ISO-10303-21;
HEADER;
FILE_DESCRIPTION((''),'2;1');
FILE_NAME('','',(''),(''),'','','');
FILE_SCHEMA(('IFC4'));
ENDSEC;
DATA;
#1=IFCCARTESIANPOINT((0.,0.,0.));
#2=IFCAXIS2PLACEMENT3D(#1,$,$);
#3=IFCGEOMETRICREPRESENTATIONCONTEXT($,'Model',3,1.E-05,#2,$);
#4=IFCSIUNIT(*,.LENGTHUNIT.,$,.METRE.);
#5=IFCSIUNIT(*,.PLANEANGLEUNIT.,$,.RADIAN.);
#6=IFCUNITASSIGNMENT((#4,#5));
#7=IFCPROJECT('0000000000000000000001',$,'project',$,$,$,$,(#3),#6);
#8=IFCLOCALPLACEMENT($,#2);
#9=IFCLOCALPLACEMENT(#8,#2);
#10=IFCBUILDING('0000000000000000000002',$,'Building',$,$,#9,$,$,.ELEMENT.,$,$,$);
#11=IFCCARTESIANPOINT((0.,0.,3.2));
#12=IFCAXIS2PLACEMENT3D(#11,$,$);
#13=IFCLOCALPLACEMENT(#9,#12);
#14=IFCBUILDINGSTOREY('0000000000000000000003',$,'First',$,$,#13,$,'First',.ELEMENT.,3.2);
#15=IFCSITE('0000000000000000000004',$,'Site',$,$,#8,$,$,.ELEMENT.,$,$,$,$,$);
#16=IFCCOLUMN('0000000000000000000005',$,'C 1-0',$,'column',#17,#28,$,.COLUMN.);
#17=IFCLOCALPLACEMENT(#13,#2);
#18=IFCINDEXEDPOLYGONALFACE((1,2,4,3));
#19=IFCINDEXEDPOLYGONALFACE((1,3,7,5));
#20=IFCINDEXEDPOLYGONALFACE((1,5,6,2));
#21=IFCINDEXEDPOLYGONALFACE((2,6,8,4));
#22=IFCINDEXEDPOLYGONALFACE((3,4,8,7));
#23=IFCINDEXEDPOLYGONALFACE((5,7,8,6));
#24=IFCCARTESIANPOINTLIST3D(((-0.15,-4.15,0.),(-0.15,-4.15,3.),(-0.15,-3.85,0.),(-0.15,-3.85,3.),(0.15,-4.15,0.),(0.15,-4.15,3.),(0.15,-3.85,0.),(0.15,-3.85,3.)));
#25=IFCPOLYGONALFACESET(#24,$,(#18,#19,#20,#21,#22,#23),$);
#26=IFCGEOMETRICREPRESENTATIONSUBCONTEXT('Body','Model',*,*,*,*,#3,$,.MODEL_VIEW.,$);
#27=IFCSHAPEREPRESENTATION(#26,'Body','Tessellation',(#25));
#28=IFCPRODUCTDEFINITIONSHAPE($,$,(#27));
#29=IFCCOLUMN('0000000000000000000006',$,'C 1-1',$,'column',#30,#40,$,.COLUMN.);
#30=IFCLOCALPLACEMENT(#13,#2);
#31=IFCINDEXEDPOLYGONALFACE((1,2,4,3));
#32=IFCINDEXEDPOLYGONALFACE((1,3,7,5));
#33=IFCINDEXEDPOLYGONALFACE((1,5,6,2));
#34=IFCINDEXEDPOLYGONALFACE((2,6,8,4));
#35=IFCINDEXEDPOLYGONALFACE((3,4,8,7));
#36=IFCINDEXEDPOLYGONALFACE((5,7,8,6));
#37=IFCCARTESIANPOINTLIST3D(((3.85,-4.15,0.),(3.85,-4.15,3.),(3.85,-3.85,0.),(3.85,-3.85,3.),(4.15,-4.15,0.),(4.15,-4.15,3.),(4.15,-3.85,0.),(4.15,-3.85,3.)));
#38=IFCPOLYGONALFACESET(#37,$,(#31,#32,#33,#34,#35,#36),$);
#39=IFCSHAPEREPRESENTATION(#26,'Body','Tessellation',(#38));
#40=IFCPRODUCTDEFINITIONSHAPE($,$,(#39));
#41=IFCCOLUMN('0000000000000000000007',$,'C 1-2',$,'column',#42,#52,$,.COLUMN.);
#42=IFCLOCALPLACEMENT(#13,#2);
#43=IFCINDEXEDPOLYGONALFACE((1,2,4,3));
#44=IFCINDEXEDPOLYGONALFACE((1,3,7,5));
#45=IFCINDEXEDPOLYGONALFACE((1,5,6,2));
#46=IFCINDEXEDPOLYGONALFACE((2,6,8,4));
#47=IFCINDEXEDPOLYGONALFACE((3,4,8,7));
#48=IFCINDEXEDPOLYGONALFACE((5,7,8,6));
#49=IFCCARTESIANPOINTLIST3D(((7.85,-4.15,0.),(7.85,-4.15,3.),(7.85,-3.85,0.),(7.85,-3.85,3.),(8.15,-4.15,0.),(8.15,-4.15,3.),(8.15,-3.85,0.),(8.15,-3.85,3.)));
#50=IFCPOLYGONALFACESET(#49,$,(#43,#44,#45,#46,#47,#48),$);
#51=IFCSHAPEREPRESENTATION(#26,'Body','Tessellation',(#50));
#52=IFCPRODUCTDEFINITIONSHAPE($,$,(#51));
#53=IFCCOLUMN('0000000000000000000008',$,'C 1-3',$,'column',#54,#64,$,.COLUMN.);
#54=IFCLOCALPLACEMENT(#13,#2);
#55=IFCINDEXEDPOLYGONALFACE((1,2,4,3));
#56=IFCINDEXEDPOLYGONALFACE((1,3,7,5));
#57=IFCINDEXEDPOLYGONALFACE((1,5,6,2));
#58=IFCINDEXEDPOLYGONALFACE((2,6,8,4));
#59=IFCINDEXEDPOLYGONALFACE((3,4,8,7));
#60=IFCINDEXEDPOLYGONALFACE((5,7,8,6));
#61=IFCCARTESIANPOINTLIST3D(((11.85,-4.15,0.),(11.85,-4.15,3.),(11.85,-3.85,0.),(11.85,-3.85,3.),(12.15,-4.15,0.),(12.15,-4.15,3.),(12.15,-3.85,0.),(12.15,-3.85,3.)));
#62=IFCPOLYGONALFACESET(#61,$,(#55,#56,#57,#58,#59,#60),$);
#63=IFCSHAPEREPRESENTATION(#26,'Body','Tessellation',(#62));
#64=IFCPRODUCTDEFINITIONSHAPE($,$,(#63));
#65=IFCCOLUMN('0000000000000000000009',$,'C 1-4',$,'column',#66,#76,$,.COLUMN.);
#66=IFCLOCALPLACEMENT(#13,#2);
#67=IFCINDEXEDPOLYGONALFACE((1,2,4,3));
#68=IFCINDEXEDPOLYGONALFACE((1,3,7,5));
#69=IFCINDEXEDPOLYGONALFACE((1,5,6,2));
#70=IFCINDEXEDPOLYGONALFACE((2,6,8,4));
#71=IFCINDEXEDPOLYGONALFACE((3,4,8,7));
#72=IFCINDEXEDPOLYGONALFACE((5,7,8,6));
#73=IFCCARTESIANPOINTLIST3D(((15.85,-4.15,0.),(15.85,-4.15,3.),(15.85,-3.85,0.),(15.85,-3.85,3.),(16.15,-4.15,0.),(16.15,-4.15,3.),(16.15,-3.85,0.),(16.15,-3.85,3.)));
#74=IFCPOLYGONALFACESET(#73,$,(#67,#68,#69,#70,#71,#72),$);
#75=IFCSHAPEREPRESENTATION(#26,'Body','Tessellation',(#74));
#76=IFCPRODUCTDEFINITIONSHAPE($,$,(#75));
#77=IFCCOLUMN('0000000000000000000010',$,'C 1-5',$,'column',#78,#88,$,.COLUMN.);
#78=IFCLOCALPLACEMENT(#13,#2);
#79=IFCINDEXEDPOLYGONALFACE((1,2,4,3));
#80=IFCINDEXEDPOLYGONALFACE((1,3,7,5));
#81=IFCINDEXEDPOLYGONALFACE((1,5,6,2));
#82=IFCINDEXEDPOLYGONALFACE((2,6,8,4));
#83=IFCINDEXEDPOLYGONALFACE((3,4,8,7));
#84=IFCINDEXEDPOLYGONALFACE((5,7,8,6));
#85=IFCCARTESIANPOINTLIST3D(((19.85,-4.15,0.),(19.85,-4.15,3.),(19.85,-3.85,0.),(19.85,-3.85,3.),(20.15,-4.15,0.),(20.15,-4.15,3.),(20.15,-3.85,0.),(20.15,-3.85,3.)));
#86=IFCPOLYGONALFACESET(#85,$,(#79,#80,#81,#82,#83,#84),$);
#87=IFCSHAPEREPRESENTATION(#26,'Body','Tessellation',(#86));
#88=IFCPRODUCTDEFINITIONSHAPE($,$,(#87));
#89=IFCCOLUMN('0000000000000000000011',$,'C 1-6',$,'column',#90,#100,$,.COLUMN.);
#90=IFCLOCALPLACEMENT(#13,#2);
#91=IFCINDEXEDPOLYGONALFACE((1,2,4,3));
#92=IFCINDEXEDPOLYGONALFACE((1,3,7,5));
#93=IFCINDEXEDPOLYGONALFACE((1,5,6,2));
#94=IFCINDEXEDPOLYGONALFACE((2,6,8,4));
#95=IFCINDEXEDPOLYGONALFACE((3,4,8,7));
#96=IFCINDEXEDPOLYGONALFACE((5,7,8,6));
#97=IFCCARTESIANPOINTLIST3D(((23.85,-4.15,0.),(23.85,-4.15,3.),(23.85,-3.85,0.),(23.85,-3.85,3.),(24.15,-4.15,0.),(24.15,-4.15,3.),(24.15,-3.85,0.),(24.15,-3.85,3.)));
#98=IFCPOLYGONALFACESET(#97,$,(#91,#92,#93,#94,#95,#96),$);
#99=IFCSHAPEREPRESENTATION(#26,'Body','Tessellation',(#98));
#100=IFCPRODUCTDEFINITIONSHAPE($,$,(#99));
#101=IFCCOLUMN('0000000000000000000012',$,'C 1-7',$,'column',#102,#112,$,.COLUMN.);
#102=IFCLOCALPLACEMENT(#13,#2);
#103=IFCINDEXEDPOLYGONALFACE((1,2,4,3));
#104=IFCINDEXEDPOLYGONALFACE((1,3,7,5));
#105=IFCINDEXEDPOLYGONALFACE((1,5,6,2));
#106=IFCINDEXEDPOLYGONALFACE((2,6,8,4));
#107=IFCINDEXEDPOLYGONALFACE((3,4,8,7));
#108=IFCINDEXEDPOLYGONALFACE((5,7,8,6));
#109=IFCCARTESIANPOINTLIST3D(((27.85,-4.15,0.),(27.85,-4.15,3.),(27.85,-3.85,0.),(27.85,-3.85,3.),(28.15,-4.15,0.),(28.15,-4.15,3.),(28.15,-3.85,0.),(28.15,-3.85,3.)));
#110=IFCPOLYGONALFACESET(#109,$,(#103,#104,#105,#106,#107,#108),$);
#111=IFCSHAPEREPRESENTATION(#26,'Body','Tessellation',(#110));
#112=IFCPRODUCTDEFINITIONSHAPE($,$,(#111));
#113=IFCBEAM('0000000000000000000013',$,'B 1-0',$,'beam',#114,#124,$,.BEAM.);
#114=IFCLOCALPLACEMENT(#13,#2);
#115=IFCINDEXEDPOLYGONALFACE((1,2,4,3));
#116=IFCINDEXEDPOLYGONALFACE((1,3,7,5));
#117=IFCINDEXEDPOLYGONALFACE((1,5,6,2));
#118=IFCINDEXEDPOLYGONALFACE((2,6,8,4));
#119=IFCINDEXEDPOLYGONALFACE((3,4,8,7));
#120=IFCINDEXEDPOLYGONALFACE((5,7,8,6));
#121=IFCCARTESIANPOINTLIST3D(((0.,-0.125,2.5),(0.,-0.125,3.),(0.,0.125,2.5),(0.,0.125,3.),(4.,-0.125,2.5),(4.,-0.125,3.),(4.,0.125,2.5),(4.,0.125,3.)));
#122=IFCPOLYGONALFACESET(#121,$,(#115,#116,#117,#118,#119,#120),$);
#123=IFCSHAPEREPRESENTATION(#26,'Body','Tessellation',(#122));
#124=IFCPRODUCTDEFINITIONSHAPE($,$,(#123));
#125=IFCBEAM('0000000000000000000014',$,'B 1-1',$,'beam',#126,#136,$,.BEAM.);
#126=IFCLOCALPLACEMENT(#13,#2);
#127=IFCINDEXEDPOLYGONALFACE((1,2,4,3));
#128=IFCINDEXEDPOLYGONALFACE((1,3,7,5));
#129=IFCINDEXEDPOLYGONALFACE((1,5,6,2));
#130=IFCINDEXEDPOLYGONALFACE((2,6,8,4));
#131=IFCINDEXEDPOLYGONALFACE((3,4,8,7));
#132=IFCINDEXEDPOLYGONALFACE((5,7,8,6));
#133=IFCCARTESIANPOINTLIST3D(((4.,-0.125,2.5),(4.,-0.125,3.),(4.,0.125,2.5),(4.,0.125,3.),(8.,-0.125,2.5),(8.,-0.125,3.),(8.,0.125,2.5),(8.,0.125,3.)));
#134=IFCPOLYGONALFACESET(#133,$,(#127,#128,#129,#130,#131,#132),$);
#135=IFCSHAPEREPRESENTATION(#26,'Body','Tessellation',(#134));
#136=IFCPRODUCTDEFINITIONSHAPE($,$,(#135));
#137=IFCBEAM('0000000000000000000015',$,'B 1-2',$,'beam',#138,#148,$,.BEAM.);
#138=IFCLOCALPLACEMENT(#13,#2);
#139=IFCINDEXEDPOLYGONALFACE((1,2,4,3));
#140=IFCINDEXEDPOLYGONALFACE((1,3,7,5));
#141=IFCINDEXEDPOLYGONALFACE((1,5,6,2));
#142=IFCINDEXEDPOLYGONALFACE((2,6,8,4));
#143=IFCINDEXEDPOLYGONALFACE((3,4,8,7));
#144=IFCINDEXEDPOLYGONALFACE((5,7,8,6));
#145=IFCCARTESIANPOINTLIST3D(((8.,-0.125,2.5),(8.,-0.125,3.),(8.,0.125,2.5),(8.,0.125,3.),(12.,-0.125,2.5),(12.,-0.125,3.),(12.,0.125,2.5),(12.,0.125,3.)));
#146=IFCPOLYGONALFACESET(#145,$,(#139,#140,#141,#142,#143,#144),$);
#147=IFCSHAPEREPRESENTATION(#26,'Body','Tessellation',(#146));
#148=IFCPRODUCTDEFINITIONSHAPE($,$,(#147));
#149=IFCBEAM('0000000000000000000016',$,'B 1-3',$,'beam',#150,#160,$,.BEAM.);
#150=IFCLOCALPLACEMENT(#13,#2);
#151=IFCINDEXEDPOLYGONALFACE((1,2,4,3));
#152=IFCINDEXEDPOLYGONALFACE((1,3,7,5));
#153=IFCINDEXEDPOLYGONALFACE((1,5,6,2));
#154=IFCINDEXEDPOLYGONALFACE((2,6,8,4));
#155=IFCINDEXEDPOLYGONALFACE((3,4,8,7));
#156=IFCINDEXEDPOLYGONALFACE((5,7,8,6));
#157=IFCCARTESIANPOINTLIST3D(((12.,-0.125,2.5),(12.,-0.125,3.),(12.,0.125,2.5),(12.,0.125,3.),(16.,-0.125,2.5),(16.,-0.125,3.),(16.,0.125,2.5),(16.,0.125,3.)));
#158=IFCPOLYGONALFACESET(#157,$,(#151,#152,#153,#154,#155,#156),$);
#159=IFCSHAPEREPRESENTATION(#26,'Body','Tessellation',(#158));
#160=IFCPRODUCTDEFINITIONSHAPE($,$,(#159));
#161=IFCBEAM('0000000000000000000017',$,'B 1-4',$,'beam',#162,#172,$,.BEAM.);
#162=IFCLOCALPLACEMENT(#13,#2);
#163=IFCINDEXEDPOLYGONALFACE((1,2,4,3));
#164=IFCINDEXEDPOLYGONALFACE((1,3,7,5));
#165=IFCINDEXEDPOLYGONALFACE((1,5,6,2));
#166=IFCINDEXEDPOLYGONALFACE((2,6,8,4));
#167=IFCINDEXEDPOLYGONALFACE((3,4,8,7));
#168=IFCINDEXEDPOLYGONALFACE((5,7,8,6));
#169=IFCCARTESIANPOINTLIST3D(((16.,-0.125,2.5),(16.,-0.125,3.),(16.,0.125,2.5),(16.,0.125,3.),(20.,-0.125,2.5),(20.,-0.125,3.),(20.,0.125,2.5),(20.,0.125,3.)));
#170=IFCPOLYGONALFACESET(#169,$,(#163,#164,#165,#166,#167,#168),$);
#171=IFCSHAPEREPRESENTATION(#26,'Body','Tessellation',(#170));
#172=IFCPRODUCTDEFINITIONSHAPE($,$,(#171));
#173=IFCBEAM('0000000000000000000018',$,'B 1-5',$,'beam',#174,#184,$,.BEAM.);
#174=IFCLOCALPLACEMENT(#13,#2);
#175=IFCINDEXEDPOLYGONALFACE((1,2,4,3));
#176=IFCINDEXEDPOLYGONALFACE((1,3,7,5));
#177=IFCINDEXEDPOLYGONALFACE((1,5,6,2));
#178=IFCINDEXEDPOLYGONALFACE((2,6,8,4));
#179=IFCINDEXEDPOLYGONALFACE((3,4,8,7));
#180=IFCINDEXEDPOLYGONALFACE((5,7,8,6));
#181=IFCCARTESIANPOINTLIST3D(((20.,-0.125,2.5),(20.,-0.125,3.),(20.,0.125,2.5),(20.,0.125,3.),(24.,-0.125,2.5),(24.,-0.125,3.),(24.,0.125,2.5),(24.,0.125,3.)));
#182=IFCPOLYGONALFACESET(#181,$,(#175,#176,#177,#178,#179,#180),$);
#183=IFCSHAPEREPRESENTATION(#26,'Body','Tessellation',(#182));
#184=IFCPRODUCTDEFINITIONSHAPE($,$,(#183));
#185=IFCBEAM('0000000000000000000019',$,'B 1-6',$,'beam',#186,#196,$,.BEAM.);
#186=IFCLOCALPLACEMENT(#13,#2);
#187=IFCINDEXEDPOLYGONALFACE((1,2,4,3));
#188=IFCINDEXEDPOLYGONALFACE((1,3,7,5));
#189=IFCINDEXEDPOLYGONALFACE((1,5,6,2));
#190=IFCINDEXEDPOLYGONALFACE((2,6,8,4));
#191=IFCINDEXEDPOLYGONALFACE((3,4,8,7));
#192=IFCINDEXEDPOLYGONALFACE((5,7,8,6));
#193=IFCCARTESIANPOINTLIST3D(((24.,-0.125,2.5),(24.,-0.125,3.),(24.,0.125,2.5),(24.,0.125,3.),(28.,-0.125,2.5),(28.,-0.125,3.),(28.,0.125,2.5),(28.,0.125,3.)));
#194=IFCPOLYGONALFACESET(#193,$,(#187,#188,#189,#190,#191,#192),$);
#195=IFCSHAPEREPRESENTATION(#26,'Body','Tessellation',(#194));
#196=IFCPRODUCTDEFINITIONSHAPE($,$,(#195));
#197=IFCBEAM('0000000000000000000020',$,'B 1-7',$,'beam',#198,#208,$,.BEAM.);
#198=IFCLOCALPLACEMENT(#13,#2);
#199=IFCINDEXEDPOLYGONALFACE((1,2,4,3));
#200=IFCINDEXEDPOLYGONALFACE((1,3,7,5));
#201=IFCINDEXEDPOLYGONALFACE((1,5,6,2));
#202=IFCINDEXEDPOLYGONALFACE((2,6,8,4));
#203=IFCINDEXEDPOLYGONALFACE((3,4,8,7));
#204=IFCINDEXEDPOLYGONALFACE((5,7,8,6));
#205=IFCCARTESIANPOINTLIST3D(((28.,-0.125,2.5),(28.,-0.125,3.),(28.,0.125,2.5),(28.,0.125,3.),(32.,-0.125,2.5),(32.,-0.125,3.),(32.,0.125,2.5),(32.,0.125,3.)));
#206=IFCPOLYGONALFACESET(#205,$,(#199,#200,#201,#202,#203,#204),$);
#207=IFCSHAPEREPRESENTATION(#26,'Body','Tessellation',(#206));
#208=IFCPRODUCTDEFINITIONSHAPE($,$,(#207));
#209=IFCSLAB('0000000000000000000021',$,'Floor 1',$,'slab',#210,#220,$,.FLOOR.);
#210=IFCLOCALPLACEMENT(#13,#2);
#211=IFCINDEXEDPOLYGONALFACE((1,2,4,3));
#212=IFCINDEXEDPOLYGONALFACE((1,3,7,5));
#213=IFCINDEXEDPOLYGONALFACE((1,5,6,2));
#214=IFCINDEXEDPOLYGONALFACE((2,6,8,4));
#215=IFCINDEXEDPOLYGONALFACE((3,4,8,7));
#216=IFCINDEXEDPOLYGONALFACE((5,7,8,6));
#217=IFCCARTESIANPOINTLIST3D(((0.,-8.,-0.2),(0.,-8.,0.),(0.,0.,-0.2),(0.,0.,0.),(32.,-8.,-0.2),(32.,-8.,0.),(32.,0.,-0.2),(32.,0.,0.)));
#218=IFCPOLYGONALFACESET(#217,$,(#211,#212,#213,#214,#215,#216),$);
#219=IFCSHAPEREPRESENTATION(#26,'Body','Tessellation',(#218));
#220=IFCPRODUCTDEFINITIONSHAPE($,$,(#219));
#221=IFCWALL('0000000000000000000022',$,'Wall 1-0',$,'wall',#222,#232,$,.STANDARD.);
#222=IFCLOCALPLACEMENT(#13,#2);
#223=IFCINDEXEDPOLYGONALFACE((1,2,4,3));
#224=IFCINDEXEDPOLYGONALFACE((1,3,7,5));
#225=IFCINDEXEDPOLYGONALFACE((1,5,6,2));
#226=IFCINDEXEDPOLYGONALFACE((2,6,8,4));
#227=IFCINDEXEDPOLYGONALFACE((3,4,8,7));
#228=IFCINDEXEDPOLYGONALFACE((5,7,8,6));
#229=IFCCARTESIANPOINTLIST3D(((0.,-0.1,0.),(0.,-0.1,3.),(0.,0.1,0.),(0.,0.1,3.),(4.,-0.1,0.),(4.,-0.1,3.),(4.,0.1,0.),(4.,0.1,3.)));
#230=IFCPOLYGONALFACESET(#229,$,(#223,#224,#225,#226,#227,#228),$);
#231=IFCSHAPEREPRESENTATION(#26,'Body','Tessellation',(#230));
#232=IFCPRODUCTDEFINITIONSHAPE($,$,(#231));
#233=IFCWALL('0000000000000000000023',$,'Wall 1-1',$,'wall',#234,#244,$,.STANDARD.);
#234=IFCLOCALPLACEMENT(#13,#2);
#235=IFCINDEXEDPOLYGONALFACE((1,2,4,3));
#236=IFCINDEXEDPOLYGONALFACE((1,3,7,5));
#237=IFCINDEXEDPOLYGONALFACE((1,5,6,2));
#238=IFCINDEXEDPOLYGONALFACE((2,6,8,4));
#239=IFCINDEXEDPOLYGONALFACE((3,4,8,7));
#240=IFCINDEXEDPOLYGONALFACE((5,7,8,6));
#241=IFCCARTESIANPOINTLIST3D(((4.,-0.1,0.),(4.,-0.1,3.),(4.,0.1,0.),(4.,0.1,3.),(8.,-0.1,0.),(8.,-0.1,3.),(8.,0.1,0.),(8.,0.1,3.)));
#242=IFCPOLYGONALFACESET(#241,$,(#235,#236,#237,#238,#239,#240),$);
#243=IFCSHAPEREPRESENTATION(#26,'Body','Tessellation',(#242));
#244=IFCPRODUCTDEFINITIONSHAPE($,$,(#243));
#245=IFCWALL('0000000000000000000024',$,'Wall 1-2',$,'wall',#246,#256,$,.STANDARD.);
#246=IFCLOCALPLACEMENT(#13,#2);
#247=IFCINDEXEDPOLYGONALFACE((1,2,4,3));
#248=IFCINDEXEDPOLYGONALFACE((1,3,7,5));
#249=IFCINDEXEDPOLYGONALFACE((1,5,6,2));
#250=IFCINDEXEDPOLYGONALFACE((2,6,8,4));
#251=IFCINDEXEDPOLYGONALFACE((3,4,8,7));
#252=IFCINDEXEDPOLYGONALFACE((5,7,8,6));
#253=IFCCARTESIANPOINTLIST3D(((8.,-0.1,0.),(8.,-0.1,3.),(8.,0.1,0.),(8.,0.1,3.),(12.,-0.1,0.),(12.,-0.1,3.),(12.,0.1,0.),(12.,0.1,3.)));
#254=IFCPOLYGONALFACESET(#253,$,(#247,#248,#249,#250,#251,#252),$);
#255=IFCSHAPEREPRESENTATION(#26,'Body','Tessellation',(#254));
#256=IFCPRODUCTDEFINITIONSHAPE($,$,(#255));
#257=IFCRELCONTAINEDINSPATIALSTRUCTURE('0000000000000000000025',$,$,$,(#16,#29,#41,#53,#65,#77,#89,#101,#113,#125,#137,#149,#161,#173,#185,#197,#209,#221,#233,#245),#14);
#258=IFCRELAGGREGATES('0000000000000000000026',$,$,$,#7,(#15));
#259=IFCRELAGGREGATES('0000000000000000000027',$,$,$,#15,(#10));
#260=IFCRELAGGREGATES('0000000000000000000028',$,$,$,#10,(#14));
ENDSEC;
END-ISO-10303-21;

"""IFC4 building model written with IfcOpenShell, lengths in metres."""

from ifc_helpers import new_model, si_unit, frame, frame_2d, origin, origin_2d, place, context, subcontext, project, spatial, polyline, rectangle, outline, extrude, element, save


model = new_model("IFC4")

# Units and contexts
model_context = context("Model", 3, precision=1e-05, world=origin())
body_context = subcontext(model_context, "Body", "Model", "MODEL_VIEW")
ifc_project = project(units=[si_unit("LENGTHUNIT", "METRE"), si_unit("PLANEANGLEUNIT", "RADIAN")], contexts=[model_context])

# Site, building, storey
site_placement = place(None, origin())
site = spatial("IfcSite", under=ifc_project, at=site_placement, Name="Site", CompositionType="ELEMENT")
building_placement = place(site_placement, origin())
building = spatial("IfcBuilding", under=site, at=building_placement, Name="Building", CompositionType="ELEMENT")
storey_placement = place(building_placement, frame((0.0, 0.0, 3.2)))
storey = spatial("IfcBuildingStorey", under=building, at=storey_placement, Name="First", LongName="First", CompositionType="ELEMENT", Elevation=3.2)

# Columns
for number, where, name in (
    (1, (0.0, -4.0, 0.0), "C 1-0"),
    (2, (4.0, -4.0, 0.0), "C 1-1"),
    (3, (8.0, -4.0, 0.0), "C 1-2"),
    (4, (12.0, -4.0, 0.0), "C 1-3"),
    (5, (16.0, -4.0, 0.0), "C 1-4"),
    (6, (20.0, -4.0, 0.0), "C 1-5"),
    (7, (24.0, -4.0, 0.0), "C 1-6"),
    (8, (28.0, -4.0, 0.0), "C 1-7"),
):
    element("IfcColumn", number, at=place(storey_placement, frame(where)), inside=storey, Name=name, ObjectType="column", PredefinedType="COLUMN", context=body_context, shape_type="SweptSolid", body=[
        extrude(rectangle(XDim=0.3, YDim=0.3, at=origin_2d()), origin(), (0.0, 0.0, 1.0), 3.0),
    ])

# Beams
for number, where, z_axis, x_axis, name in (
    (9, (0.0, 0.0, 2.75), (1.0, 0.0, 0.0), (0.0, 0.0, 1.0), "B 1-0"),
    (10, (4.0, 0.0, 2.75), (1.0, 0.0, 0.0), (0.0, 0.0, 1.0), "B 1-1"),
    (11, (8.0, 0.0, 2.75), (1.0, 0.0, 0.0), (0.0, 0.0, 1.0), "B 1-2"),
    (12, (12.0, 0.0, 2.75), (1.0, 0.0, 0.0), (0.0, 0.0, 1.0), "B 1-3"),
    (13, (16.0, 0.0, 2.75), (1.0, 0.0, 0.0), (0.0, 0.0, 1.0), "B 1-4"),
    (14, (20.0, 0.0, 2.75), (1.0, 0.0, 0.0), (0.0, 0.0, 1.0), "B 1-5"),
    (15, (24.0, 0.0, 2.75), (1.0, 0.0, 0.0), (0.0, 0.0, 1.0), "B 1-6"),
    (16, (28.0, 0.0, 2.75), (1.0, 0.0, 0.0), (0.0, 0.0, 1.0), "B 1-7"),
):
    element("IfcBeam", number, at=place(storey_placement, frame(where, z_axis=z_axis, x_axis=x_axis)), inside=storey, Name=name, ObjectType="beam", PredefinedType="BEAM", context=body_context, shape_type="SweptSolid", body=[
        extrude(rectangle(XDim=0.5, YDim=0.25, at=origin_2d()), origin(), (0.0, 0.0, 1.0), 4.0),
    ])

# Slab
slab_placement = place(storey_placement, frame((0.0, 0.0, -0.2)))
element("IfcSlab", 17, at=slab_placement, inside=storey, Name="Floor 1", ObjectType="slab", PredefinedType="FLOOR", context=body_context, shape_type="SweptSolid", body=[
    extrude(outline(polyline([(0.0, -8.0), (32.0, -8.0), (32.0, 0.0), (0.0, 0.0), (0.0, -8.0)])), origin(), (0.0, 0.0, 1.0), 0.2),
])

# Walls
for number, where, z_axis, x_axis, name in (
    (18, (0.0, 0.0, 0.0), (0.0, 0.0, 1.0), (1.0, 0.0, 0.0), "Wall 1-0"),
    (19, (4.0, 0.0, 0.0), (0.0, 0.0, 1.0), (1.0, 0.0, 0.0), "Wall 1-1"),
    (20, (8.0, 0.0, 0.0), (0.0, 0.0, 1.0), (1.0, 0.0, 0.0), "Wall 1-2"),
):
    element("IfcWall", number, at=place(storey_placement, frame(where, z_axis=z_axis, x_axis=x_axis)), inside=storey, Name=name, ObjectType="wall", PredefinedType="STANDARD", context=body_context, shape_type="SweptSolid", body=[
        extrude(rectangle(XDim=4.0, YDim=0.2, at=frame_2d((2.0, 0.0))), origin(), (0.0, 0.0, 1.0), 3.0),
    ])

save(model, "model.ifc")
